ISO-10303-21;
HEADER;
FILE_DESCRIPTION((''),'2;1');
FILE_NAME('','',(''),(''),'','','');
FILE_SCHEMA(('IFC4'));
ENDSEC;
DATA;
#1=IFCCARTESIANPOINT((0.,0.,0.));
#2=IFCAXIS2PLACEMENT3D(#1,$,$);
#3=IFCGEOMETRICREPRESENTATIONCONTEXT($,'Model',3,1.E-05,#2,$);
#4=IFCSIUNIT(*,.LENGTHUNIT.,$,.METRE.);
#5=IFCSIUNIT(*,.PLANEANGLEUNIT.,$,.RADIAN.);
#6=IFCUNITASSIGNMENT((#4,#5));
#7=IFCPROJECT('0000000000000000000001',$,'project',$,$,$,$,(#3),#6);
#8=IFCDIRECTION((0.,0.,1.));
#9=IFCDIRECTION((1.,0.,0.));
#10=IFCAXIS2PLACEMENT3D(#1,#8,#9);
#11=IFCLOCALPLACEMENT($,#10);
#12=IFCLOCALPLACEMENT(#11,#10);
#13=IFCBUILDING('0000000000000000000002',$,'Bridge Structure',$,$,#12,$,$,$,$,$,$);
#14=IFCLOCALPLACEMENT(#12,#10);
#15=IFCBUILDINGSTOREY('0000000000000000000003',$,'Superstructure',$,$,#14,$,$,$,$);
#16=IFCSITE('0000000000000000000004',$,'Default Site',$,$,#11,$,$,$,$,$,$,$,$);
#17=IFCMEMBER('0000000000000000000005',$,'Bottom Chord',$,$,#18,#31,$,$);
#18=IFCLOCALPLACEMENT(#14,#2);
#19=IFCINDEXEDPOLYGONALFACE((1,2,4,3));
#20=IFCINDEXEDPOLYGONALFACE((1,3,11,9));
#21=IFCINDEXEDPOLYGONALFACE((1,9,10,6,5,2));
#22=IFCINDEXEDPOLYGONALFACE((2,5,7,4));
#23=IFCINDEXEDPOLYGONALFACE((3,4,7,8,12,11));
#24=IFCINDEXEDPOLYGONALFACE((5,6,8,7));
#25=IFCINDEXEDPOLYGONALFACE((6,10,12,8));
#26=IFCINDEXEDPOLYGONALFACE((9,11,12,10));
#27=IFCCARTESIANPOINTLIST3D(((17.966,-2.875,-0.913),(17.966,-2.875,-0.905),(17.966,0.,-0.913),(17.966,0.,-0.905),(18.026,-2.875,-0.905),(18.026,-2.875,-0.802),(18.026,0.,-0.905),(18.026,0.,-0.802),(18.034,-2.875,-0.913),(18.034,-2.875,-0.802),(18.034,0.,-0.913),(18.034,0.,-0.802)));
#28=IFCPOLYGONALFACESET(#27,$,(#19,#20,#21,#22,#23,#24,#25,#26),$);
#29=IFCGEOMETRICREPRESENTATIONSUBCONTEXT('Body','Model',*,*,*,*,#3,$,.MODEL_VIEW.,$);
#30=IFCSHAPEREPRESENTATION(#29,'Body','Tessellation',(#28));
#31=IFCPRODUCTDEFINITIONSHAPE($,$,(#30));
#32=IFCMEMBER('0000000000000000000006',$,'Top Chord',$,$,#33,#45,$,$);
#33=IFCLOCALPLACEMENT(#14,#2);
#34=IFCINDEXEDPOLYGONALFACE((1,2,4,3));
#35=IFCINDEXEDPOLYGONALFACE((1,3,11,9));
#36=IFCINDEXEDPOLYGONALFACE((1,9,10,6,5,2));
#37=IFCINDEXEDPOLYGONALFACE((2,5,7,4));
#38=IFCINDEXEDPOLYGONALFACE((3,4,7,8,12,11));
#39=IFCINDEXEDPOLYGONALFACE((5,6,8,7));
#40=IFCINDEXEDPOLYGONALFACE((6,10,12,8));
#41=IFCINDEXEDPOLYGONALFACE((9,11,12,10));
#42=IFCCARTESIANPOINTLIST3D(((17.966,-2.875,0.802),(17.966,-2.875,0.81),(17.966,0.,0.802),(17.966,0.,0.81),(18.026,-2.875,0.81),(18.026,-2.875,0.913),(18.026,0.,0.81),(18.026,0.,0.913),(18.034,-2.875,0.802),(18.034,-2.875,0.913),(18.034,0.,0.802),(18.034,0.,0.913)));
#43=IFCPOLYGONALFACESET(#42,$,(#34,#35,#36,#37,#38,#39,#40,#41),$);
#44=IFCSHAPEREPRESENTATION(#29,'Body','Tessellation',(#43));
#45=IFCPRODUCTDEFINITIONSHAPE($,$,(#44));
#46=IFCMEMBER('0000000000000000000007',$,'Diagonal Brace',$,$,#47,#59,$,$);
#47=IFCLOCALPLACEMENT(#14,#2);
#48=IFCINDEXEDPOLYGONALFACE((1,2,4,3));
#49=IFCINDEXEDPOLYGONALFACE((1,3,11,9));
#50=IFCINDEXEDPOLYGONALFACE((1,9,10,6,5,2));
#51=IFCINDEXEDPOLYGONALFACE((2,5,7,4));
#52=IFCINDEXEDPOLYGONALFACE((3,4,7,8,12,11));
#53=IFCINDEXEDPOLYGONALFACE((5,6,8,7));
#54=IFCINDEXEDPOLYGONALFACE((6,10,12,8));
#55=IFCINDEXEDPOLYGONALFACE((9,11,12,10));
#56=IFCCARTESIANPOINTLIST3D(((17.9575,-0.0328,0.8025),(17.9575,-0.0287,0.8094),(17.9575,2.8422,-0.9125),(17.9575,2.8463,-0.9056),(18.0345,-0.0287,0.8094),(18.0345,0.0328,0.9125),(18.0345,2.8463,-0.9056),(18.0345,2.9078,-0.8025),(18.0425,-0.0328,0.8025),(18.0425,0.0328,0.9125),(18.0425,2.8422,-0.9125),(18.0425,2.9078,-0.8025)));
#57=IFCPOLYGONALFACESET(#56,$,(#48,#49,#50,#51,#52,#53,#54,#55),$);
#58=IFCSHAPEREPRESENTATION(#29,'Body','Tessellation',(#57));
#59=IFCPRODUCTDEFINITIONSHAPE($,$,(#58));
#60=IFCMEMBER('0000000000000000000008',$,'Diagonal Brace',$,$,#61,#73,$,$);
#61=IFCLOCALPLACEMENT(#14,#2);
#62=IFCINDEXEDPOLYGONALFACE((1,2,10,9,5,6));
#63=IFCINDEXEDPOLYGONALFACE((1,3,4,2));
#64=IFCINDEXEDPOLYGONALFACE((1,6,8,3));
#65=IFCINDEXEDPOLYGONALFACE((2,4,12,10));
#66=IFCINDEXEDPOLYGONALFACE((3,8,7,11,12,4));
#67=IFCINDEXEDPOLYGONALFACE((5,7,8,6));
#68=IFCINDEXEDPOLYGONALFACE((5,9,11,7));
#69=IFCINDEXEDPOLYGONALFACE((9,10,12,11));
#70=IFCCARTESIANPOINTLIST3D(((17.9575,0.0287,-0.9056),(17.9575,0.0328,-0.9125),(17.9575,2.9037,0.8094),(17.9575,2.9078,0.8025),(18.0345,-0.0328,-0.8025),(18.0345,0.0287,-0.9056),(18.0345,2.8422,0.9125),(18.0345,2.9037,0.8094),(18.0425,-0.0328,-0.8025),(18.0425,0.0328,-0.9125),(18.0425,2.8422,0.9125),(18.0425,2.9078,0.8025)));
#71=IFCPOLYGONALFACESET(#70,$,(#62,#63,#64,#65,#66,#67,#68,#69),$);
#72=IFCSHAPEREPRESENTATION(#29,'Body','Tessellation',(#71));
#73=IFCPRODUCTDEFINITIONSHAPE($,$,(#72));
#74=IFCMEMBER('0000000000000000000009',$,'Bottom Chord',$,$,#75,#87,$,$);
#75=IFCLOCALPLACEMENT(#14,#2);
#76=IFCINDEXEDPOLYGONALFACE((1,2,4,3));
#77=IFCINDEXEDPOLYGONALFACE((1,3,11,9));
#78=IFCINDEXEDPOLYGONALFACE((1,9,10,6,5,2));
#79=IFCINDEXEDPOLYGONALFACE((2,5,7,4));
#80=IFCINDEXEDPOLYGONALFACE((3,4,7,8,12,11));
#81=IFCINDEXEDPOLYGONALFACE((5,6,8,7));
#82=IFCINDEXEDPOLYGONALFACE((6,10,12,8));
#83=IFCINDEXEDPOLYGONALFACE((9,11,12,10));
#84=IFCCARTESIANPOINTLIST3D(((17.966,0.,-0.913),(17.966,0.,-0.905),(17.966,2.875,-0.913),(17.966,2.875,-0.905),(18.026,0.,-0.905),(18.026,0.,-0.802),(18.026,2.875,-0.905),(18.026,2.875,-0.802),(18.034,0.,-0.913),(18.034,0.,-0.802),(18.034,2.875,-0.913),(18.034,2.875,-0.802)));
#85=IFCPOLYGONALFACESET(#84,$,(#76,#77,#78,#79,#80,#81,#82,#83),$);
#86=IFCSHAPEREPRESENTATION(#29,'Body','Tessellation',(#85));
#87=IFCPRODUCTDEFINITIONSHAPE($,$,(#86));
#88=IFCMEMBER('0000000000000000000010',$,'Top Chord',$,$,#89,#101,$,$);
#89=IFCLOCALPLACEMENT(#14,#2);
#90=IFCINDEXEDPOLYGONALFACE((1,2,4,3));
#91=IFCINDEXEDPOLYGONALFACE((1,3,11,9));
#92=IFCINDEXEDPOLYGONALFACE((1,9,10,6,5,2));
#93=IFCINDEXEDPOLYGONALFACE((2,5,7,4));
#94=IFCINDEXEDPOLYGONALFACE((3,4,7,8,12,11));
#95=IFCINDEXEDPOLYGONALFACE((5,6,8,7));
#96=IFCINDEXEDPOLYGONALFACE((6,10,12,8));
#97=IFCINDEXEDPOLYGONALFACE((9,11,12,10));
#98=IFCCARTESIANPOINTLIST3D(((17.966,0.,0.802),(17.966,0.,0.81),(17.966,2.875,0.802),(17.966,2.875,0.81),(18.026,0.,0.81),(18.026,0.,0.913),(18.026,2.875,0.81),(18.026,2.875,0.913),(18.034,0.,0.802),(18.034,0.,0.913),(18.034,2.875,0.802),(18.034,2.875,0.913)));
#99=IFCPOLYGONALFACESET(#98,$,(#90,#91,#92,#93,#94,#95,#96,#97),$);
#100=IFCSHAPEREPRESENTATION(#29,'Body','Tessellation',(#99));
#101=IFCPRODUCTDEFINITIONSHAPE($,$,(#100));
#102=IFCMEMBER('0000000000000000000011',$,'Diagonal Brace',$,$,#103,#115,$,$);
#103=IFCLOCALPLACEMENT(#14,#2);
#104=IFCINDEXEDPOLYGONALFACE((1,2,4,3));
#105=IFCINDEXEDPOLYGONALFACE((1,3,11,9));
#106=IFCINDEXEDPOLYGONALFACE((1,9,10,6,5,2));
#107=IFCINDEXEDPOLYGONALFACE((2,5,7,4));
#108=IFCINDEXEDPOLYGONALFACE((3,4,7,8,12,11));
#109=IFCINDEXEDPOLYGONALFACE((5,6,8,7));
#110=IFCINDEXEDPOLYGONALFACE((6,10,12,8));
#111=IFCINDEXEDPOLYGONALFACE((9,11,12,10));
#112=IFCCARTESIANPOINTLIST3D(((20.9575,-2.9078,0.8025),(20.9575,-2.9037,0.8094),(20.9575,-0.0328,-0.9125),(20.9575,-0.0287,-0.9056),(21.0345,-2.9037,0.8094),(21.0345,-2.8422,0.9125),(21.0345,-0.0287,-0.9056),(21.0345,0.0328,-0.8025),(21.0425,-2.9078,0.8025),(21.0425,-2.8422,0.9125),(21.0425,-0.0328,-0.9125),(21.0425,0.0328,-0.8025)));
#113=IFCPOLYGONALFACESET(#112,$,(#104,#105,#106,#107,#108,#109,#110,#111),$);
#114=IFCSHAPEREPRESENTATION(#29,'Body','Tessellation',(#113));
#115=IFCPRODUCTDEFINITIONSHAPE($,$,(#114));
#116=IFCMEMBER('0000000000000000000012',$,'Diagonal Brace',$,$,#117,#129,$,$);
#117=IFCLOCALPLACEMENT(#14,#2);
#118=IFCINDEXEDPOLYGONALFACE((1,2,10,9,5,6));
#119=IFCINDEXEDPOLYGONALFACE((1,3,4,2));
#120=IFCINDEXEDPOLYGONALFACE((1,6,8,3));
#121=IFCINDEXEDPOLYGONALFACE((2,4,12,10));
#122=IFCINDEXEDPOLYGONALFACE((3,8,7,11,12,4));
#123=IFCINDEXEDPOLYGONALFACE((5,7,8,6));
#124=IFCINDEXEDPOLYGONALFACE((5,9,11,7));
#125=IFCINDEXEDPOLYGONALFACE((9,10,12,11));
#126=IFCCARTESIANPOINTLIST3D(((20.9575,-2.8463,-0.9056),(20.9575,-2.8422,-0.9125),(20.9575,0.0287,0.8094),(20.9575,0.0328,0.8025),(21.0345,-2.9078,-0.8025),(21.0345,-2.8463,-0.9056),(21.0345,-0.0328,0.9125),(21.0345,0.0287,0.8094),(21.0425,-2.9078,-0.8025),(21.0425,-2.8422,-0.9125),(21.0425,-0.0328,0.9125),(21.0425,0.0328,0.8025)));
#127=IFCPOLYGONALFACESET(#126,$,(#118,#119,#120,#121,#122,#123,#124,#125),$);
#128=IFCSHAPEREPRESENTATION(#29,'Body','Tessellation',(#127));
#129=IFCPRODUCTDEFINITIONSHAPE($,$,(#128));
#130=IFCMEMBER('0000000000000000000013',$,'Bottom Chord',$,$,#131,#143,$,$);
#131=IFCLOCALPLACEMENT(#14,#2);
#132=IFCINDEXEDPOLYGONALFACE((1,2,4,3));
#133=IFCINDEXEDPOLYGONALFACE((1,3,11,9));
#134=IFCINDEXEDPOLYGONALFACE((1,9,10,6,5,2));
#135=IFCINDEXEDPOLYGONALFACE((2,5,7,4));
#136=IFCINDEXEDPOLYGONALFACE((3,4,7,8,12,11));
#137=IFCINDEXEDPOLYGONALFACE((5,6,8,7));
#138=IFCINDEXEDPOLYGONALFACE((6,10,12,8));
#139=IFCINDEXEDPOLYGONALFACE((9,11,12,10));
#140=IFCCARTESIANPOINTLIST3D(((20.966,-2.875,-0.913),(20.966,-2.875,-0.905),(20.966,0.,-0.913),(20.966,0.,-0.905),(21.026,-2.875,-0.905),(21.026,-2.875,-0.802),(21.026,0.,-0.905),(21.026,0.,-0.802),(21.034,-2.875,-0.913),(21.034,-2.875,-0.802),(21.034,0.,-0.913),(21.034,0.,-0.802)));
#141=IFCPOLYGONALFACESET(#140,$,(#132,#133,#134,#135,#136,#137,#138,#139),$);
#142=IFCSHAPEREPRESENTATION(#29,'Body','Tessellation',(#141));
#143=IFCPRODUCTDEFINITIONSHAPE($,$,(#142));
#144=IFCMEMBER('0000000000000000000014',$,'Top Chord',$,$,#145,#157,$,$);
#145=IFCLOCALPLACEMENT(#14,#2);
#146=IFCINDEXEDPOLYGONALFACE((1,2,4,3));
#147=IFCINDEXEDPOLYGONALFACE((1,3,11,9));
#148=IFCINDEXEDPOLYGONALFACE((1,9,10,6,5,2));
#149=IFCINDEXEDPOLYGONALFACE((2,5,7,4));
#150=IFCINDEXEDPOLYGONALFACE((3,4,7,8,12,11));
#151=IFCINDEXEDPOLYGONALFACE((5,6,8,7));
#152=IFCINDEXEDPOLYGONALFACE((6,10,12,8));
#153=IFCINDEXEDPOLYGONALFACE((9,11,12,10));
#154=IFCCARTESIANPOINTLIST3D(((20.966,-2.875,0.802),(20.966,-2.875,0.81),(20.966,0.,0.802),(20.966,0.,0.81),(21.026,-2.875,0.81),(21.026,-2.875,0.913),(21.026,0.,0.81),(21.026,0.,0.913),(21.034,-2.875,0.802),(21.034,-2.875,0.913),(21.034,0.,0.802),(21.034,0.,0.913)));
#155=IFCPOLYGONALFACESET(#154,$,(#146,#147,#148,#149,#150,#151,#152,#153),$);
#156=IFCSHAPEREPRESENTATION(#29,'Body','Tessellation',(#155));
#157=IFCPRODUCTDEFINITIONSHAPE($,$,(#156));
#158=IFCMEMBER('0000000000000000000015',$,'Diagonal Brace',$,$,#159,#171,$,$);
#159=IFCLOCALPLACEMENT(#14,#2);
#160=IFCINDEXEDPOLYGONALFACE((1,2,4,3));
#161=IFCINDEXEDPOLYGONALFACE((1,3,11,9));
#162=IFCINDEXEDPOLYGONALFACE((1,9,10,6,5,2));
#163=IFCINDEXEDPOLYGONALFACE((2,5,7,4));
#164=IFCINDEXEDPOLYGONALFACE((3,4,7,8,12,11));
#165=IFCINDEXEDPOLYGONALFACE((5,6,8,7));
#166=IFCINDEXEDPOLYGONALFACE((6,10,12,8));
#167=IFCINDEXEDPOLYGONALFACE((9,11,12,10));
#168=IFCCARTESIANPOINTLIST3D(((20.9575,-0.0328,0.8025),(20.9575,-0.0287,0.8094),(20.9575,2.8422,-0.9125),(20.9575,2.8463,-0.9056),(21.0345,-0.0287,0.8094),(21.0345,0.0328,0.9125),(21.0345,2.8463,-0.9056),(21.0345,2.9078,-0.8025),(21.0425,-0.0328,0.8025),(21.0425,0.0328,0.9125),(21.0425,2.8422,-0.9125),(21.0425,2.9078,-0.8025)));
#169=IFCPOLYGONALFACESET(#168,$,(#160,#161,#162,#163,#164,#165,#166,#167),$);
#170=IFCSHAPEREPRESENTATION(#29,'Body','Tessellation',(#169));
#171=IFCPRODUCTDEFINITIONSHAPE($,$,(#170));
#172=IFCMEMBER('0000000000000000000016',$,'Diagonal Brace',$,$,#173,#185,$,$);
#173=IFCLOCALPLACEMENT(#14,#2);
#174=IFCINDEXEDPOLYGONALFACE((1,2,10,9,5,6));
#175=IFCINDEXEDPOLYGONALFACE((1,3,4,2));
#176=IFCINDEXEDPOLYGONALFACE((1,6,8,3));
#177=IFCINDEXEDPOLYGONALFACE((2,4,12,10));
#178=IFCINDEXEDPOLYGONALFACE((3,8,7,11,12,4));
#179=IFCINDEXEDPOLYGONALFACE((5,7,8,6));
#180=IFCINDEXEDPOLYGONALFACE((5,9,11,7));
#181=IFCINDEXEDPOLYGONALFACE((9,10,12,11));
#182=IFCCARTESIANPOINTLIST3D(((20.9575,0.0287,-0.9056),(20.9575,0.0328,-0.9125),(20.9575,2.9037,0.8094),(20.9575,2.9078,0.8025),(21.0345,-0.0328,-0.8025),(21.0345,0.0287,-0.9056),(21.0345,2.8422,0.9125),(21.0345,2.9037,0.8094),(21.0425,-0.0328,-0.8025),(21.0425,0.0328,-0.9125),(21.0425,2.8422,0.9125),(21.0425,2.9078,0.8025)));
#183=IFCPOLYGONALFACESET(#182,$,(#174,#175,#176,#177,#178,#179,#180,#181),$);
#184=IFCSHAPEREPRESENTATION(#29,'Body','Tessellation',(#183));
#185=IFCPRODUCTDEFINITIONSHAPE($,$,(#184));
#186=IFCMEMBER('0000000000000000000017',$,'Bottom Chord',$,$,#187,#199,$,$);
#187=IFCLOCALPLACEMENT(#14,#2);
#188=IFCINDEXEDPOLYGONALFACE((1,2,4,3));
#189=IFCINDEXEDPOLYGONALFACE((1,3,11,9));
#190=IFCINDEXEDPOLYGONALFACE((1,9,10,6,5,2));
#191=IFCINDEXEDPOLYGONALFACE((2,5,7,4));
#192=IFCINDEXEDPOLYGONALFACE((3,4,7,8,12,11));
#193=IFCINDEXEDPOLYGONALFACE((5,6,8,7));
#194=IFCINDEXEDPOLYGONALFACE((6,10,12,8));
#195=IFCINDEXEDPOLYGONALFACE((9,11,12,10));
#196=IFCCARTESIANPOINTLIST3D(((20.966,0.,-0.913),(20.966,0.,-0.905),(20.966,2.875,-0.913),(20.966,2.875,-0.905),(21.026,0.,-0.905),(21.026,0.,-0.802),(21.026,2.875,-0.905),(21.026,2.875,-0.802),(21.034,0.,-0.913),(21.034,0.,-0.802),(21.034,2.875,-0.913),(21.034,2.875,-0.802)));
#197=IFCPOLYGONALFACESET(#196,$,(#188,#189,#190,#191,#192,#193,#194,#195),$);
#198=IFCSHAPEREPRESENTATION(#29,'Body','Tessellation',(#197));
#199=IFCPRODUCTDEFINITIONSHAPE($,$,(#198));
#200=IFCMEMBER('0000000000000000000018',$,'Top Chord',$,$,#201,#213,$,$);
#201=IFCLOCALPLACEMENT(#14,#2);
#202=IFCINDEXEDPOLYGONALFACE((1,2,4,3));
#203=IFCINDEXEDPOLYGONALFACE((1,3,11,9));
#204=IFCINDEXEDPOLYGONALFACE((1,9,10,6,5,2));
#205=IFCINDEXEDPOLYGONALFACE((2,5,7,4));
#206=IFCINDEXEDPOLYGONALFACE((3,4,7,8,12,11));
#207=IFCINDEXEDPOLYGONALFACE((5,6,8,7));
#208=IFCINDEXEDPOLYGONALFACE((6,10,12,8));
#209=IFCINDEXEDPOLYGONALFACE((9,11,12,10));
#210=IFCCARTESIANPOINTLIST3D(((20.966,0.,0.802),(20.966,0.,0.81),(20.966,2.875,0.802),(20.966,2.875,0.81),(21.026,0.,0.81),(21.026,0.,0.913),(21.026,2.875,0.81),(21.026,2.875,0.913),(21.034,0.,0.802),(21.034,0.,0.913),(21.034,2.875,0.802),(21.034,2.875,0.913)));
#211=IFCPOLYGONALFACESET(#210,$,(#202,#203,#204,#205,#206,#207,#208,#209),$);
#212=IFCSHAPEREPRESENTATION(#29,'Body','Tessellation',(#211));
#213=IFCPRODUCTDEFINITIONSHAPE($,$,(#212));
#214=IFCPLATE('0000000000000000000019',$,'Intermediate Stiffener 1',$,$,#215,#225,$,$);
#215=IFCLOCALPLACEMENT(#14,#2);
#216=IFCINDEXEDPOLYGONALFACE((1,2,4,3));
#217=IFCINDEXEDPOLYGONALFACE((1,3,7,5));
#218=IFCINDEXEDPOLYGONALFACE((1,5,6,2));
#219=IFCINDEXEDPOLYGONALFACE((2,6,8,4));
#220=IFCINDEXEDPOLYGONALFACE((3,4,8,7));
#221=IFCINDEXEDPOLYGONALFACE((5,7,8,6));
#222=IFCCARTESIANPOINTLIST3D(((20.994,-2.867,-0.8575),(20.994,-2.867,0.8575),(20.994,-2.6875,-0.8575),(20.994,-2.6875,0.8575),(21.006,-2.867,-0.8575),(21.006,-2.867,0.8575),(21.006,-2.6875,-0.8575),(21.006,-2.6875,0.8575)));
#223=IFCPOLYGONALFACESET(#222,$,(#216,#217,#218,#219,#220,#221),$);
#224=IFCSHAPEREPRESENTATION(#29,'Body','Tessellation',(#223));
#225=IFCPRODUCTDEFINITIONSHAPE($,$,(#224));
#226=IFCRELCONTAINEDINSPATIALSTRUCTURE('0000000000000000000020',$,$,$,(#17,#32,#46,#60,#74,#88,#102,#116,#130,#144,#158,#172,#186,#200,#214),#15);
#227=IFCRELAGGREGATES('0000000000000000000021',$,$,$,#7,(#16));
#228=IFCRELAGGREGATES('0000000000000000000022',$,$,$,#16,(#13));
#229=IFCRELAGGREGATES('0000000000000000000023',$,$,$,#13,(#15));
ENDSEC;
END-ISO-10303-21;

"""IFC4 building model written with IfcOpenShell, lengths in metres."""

from ifc_helpers import new_model, si_unit, frame, origin, origin_with_axes, origin_2d_with_axis, place, context, subcontext, project, spatial, rectangle, l_section, extrude, element, save


model = new_model("IFC4")

# Units and contexts
model_context = context("Model", 3, precision=1e-05, world=origin())
body_context = subcontext(model_context, "Body", "Model", "MODEL_VIEW")
ifc_project = project(units=[si_unit("LENGTHUNIT", "METRE"), si_unit("PLANEANGLEUNIT", "RADIAN")], contexts=[model_context])

# Site, building, storey
site_placement = place(None, origin_with_axes())
site = spatial("IfcSite", under=ifc_project, at=site_placement, Name="Default Site")
building_placement = place(site_placement, origin_with_axes())
building = spatial("IfcBuilding", under=site, at=building_placement, Name="Bridge Structure")
storey_placement = place(building_placement, origin_with_axes())
storey = spatial("IfcBuildingStorey", under=building, at=storey_placement, Name="Superstructure")

# Members
for number, where, z_axis, x_axis, name in (
    (1, (18.0, -2.875, -0.8575), (0.0, 1.0, 0.0), (-1.0, 0.0, 0.0), "Bottom Chord"),
    (2, (18.0, -2.875, 0.8575), (0.0, 1.0, 0.0), (-1.0, 0.0, 0.0), "Top Chord"),
):
    element("IfcMember", number, at=place(storey_placement, frame(where, z_axis=z_axis, x_axis=x_axis)), inside=storey, Name=name, context=body_context, shape_type="SweptSolid", body=[
        extrude(l_section(Depth=0.111, Width=0.068, Thickness=0.008, at=origin_2d_with_axis()), origin_with_axes(), (0.0, 0.0, 1.0), 2.875),
    ])
for number, where, z_axis, x_axis, name in (
    (3, (18.0, 0.0, 0.8575), (0.0, 0.858808, -0.512298), (-1.0, 0.0, 0.0), "Diagonal Brace"),
    (4, (18.0, 0.0, -0.8575), (0.0, 0.858808, 0.512298), (-1.0, 0.0, 0.0), "Diagonal Brace"),
):
    element("IfcMember", number, at=place(storey_placement, frame(where, z_axis=z_axis, x_axis=x_axis)), inside=storey, Name=name, context=body_context, shape_type="SweptSolid", body=[
        extrude(l_section(Depth=0.128, Width=0.085, Thickness=0.008, at=origin_2d_with_axis()), origin_with_axes(), (0.0, 0.0, 1.0), 3.3477),
    ])
for number, where, z_axis, x_axis, name in (
    (5, (18.0, 0.0, -0.8575), (0.0, 1.0, 0.0), (-1.0, 0.0, 0.0), "Bottom Chord"),
    (6, (18.0, 0.0, 0.8575), (0.0, 1.0, 0.0), (-1.0, 0.0, 0.0), "Top Chord"),
):
    element("IfcMember", number, at=place(storey_placement, frame(where, z_axis=z_axis, x_axis=x_axis)), inside=storey, Name=name, context=body_context, shape_type="SweptSolid", body=[
        extrude(l_section(Depth=0.111, Width=0.068, Thickness=0.008, at=origin_2d_with_axis()), origin_with_axes(), (0.0, 0.0, 1.0), 2.875),
    ])
for number, where, z_axis, x_axis, name in (
    (7, (21.0, -2.875, 0.8575), (0.0, 0.858808, -0.512298), (-1.0, 0.0, 0.0), "Diagonal Brace"),
    (8, (21.0, -2.875, -0.8575), (0.0, 0.858808, 0.512298), (-1.0, 0.0, 0.0), "Diagonal Brace"),
):
    element("IfcMember", number, at=place(storey_placement, frame(where, z_axis=z_axis, x_axis=x_axis)), inside=storey, Name=name, context=body_context, shape_type="SweptSolid", body=[
        extrude(l_section(Depth=0.128, Width=0.085, Thickness=0.008, at=origin_2d_with_axis()), origin_with_axes(), (0.0, 0.0, 1.0), 3.3477),
    ])
for number, where, z_axis, x_axis, name in (
    (9, (21.0, -2.875, -0.8575), (0.0, 1.0, 0.0), (-1.0, 0.0, 0.0), "Bottom Chord"),
    (10, (21.0, -2.875, 0.8575), (0.0, 1.0, 0.0), (-1.0, 0.0, 0.0), "Top Chord"),
):
    element("IfcMember", number, at=place(storey_placement, frame(where, z_axis=z_axis, x_axis=x_axis)), inside=storey, Name=name, context=body_context, shape_type="SweptSolid", body=[
        extrude(l_section(Depth=0.111, Width=0.068, Thickness=0.008, at=origin_2d_with_axis()), origin_with_axes(), (0.0, 0.0, 1.0), 2.875),
    ])
for number, where, z_axis, x_axis, name in (
    (11, (21.0, 0.0, 0.8575), (0.0, 0.858808, -0.512298), (-1.0, 0.0, 0.0), "Diagonal Brace"),
    (12, (21.0, 0.0, -0.8575), (0.0, 0.858808, 0.512298), (-1.0, 0.0, 0.0), "Diagonal Brace"),
):
    element("IfcMember", number, at=place(storey_placement, frame(where, z_axis=z_axis, x_axis=x_axis)), inside=storey, Name=name, context=body_context, shape_type="SweptSolid", body=[
        extrude(l_section(Depth=0.128, Width=0.085, Thickness=0.008, at=origin_2d_with_axis()), origin_with_axes(), (0.0, 0.0, 1.0), 3.3477),
    ])
for number, where, z_axis, x_axis, name in (
    (13, (21.0, 0.0, -0.8575), (0.0, 1.0, 0.0), (-1.0, 0.0, 0.0), "Bottom Chord"),
    (14, (21.0, 0.0, 0.8575), (0.0, 1.0, 0.0), (-1.0, 0.0, 0.0), "Top Chord"),
):
    element("IfcMember", number, at=place(storey_placement, frame(where, z_axis=z_axis, x_axis=x_axis)), inside=storey, Name=name, context=body_context, shape_type="SweptSolid", body=[
        extrude(l_section(Depth=0.111, Width=0.068, Thickness=0.008, at=origin_2d_with_axis()), origin_with_axes(), (0.0, 0.0, 1.0), 2.875),
    ])

# Plate
for number, where, z_axis, x_axis, name in (
    (15, (21.0, -2.7772, -0.8575), (0.0, 0.0, 1.0), (1.0, 0.0, 0.0), "Intermediate Stiffener 1"),
):
    element("IfcPlate", number, at=place(storey_placement, frame(where, z_axis=z_axis, x_axis=x_axis)), inside=storey, Name=name, context=body_context, shape_type="SweptSolid", body=[
        extrude(rectangle(XDim=0.012, YDim=0.1795, at=origin_2d_with_axis()), origin_with_axes(), (0.0, 0.0, 1.0), 1.715),
    ])

save(model, "model.ifc")
